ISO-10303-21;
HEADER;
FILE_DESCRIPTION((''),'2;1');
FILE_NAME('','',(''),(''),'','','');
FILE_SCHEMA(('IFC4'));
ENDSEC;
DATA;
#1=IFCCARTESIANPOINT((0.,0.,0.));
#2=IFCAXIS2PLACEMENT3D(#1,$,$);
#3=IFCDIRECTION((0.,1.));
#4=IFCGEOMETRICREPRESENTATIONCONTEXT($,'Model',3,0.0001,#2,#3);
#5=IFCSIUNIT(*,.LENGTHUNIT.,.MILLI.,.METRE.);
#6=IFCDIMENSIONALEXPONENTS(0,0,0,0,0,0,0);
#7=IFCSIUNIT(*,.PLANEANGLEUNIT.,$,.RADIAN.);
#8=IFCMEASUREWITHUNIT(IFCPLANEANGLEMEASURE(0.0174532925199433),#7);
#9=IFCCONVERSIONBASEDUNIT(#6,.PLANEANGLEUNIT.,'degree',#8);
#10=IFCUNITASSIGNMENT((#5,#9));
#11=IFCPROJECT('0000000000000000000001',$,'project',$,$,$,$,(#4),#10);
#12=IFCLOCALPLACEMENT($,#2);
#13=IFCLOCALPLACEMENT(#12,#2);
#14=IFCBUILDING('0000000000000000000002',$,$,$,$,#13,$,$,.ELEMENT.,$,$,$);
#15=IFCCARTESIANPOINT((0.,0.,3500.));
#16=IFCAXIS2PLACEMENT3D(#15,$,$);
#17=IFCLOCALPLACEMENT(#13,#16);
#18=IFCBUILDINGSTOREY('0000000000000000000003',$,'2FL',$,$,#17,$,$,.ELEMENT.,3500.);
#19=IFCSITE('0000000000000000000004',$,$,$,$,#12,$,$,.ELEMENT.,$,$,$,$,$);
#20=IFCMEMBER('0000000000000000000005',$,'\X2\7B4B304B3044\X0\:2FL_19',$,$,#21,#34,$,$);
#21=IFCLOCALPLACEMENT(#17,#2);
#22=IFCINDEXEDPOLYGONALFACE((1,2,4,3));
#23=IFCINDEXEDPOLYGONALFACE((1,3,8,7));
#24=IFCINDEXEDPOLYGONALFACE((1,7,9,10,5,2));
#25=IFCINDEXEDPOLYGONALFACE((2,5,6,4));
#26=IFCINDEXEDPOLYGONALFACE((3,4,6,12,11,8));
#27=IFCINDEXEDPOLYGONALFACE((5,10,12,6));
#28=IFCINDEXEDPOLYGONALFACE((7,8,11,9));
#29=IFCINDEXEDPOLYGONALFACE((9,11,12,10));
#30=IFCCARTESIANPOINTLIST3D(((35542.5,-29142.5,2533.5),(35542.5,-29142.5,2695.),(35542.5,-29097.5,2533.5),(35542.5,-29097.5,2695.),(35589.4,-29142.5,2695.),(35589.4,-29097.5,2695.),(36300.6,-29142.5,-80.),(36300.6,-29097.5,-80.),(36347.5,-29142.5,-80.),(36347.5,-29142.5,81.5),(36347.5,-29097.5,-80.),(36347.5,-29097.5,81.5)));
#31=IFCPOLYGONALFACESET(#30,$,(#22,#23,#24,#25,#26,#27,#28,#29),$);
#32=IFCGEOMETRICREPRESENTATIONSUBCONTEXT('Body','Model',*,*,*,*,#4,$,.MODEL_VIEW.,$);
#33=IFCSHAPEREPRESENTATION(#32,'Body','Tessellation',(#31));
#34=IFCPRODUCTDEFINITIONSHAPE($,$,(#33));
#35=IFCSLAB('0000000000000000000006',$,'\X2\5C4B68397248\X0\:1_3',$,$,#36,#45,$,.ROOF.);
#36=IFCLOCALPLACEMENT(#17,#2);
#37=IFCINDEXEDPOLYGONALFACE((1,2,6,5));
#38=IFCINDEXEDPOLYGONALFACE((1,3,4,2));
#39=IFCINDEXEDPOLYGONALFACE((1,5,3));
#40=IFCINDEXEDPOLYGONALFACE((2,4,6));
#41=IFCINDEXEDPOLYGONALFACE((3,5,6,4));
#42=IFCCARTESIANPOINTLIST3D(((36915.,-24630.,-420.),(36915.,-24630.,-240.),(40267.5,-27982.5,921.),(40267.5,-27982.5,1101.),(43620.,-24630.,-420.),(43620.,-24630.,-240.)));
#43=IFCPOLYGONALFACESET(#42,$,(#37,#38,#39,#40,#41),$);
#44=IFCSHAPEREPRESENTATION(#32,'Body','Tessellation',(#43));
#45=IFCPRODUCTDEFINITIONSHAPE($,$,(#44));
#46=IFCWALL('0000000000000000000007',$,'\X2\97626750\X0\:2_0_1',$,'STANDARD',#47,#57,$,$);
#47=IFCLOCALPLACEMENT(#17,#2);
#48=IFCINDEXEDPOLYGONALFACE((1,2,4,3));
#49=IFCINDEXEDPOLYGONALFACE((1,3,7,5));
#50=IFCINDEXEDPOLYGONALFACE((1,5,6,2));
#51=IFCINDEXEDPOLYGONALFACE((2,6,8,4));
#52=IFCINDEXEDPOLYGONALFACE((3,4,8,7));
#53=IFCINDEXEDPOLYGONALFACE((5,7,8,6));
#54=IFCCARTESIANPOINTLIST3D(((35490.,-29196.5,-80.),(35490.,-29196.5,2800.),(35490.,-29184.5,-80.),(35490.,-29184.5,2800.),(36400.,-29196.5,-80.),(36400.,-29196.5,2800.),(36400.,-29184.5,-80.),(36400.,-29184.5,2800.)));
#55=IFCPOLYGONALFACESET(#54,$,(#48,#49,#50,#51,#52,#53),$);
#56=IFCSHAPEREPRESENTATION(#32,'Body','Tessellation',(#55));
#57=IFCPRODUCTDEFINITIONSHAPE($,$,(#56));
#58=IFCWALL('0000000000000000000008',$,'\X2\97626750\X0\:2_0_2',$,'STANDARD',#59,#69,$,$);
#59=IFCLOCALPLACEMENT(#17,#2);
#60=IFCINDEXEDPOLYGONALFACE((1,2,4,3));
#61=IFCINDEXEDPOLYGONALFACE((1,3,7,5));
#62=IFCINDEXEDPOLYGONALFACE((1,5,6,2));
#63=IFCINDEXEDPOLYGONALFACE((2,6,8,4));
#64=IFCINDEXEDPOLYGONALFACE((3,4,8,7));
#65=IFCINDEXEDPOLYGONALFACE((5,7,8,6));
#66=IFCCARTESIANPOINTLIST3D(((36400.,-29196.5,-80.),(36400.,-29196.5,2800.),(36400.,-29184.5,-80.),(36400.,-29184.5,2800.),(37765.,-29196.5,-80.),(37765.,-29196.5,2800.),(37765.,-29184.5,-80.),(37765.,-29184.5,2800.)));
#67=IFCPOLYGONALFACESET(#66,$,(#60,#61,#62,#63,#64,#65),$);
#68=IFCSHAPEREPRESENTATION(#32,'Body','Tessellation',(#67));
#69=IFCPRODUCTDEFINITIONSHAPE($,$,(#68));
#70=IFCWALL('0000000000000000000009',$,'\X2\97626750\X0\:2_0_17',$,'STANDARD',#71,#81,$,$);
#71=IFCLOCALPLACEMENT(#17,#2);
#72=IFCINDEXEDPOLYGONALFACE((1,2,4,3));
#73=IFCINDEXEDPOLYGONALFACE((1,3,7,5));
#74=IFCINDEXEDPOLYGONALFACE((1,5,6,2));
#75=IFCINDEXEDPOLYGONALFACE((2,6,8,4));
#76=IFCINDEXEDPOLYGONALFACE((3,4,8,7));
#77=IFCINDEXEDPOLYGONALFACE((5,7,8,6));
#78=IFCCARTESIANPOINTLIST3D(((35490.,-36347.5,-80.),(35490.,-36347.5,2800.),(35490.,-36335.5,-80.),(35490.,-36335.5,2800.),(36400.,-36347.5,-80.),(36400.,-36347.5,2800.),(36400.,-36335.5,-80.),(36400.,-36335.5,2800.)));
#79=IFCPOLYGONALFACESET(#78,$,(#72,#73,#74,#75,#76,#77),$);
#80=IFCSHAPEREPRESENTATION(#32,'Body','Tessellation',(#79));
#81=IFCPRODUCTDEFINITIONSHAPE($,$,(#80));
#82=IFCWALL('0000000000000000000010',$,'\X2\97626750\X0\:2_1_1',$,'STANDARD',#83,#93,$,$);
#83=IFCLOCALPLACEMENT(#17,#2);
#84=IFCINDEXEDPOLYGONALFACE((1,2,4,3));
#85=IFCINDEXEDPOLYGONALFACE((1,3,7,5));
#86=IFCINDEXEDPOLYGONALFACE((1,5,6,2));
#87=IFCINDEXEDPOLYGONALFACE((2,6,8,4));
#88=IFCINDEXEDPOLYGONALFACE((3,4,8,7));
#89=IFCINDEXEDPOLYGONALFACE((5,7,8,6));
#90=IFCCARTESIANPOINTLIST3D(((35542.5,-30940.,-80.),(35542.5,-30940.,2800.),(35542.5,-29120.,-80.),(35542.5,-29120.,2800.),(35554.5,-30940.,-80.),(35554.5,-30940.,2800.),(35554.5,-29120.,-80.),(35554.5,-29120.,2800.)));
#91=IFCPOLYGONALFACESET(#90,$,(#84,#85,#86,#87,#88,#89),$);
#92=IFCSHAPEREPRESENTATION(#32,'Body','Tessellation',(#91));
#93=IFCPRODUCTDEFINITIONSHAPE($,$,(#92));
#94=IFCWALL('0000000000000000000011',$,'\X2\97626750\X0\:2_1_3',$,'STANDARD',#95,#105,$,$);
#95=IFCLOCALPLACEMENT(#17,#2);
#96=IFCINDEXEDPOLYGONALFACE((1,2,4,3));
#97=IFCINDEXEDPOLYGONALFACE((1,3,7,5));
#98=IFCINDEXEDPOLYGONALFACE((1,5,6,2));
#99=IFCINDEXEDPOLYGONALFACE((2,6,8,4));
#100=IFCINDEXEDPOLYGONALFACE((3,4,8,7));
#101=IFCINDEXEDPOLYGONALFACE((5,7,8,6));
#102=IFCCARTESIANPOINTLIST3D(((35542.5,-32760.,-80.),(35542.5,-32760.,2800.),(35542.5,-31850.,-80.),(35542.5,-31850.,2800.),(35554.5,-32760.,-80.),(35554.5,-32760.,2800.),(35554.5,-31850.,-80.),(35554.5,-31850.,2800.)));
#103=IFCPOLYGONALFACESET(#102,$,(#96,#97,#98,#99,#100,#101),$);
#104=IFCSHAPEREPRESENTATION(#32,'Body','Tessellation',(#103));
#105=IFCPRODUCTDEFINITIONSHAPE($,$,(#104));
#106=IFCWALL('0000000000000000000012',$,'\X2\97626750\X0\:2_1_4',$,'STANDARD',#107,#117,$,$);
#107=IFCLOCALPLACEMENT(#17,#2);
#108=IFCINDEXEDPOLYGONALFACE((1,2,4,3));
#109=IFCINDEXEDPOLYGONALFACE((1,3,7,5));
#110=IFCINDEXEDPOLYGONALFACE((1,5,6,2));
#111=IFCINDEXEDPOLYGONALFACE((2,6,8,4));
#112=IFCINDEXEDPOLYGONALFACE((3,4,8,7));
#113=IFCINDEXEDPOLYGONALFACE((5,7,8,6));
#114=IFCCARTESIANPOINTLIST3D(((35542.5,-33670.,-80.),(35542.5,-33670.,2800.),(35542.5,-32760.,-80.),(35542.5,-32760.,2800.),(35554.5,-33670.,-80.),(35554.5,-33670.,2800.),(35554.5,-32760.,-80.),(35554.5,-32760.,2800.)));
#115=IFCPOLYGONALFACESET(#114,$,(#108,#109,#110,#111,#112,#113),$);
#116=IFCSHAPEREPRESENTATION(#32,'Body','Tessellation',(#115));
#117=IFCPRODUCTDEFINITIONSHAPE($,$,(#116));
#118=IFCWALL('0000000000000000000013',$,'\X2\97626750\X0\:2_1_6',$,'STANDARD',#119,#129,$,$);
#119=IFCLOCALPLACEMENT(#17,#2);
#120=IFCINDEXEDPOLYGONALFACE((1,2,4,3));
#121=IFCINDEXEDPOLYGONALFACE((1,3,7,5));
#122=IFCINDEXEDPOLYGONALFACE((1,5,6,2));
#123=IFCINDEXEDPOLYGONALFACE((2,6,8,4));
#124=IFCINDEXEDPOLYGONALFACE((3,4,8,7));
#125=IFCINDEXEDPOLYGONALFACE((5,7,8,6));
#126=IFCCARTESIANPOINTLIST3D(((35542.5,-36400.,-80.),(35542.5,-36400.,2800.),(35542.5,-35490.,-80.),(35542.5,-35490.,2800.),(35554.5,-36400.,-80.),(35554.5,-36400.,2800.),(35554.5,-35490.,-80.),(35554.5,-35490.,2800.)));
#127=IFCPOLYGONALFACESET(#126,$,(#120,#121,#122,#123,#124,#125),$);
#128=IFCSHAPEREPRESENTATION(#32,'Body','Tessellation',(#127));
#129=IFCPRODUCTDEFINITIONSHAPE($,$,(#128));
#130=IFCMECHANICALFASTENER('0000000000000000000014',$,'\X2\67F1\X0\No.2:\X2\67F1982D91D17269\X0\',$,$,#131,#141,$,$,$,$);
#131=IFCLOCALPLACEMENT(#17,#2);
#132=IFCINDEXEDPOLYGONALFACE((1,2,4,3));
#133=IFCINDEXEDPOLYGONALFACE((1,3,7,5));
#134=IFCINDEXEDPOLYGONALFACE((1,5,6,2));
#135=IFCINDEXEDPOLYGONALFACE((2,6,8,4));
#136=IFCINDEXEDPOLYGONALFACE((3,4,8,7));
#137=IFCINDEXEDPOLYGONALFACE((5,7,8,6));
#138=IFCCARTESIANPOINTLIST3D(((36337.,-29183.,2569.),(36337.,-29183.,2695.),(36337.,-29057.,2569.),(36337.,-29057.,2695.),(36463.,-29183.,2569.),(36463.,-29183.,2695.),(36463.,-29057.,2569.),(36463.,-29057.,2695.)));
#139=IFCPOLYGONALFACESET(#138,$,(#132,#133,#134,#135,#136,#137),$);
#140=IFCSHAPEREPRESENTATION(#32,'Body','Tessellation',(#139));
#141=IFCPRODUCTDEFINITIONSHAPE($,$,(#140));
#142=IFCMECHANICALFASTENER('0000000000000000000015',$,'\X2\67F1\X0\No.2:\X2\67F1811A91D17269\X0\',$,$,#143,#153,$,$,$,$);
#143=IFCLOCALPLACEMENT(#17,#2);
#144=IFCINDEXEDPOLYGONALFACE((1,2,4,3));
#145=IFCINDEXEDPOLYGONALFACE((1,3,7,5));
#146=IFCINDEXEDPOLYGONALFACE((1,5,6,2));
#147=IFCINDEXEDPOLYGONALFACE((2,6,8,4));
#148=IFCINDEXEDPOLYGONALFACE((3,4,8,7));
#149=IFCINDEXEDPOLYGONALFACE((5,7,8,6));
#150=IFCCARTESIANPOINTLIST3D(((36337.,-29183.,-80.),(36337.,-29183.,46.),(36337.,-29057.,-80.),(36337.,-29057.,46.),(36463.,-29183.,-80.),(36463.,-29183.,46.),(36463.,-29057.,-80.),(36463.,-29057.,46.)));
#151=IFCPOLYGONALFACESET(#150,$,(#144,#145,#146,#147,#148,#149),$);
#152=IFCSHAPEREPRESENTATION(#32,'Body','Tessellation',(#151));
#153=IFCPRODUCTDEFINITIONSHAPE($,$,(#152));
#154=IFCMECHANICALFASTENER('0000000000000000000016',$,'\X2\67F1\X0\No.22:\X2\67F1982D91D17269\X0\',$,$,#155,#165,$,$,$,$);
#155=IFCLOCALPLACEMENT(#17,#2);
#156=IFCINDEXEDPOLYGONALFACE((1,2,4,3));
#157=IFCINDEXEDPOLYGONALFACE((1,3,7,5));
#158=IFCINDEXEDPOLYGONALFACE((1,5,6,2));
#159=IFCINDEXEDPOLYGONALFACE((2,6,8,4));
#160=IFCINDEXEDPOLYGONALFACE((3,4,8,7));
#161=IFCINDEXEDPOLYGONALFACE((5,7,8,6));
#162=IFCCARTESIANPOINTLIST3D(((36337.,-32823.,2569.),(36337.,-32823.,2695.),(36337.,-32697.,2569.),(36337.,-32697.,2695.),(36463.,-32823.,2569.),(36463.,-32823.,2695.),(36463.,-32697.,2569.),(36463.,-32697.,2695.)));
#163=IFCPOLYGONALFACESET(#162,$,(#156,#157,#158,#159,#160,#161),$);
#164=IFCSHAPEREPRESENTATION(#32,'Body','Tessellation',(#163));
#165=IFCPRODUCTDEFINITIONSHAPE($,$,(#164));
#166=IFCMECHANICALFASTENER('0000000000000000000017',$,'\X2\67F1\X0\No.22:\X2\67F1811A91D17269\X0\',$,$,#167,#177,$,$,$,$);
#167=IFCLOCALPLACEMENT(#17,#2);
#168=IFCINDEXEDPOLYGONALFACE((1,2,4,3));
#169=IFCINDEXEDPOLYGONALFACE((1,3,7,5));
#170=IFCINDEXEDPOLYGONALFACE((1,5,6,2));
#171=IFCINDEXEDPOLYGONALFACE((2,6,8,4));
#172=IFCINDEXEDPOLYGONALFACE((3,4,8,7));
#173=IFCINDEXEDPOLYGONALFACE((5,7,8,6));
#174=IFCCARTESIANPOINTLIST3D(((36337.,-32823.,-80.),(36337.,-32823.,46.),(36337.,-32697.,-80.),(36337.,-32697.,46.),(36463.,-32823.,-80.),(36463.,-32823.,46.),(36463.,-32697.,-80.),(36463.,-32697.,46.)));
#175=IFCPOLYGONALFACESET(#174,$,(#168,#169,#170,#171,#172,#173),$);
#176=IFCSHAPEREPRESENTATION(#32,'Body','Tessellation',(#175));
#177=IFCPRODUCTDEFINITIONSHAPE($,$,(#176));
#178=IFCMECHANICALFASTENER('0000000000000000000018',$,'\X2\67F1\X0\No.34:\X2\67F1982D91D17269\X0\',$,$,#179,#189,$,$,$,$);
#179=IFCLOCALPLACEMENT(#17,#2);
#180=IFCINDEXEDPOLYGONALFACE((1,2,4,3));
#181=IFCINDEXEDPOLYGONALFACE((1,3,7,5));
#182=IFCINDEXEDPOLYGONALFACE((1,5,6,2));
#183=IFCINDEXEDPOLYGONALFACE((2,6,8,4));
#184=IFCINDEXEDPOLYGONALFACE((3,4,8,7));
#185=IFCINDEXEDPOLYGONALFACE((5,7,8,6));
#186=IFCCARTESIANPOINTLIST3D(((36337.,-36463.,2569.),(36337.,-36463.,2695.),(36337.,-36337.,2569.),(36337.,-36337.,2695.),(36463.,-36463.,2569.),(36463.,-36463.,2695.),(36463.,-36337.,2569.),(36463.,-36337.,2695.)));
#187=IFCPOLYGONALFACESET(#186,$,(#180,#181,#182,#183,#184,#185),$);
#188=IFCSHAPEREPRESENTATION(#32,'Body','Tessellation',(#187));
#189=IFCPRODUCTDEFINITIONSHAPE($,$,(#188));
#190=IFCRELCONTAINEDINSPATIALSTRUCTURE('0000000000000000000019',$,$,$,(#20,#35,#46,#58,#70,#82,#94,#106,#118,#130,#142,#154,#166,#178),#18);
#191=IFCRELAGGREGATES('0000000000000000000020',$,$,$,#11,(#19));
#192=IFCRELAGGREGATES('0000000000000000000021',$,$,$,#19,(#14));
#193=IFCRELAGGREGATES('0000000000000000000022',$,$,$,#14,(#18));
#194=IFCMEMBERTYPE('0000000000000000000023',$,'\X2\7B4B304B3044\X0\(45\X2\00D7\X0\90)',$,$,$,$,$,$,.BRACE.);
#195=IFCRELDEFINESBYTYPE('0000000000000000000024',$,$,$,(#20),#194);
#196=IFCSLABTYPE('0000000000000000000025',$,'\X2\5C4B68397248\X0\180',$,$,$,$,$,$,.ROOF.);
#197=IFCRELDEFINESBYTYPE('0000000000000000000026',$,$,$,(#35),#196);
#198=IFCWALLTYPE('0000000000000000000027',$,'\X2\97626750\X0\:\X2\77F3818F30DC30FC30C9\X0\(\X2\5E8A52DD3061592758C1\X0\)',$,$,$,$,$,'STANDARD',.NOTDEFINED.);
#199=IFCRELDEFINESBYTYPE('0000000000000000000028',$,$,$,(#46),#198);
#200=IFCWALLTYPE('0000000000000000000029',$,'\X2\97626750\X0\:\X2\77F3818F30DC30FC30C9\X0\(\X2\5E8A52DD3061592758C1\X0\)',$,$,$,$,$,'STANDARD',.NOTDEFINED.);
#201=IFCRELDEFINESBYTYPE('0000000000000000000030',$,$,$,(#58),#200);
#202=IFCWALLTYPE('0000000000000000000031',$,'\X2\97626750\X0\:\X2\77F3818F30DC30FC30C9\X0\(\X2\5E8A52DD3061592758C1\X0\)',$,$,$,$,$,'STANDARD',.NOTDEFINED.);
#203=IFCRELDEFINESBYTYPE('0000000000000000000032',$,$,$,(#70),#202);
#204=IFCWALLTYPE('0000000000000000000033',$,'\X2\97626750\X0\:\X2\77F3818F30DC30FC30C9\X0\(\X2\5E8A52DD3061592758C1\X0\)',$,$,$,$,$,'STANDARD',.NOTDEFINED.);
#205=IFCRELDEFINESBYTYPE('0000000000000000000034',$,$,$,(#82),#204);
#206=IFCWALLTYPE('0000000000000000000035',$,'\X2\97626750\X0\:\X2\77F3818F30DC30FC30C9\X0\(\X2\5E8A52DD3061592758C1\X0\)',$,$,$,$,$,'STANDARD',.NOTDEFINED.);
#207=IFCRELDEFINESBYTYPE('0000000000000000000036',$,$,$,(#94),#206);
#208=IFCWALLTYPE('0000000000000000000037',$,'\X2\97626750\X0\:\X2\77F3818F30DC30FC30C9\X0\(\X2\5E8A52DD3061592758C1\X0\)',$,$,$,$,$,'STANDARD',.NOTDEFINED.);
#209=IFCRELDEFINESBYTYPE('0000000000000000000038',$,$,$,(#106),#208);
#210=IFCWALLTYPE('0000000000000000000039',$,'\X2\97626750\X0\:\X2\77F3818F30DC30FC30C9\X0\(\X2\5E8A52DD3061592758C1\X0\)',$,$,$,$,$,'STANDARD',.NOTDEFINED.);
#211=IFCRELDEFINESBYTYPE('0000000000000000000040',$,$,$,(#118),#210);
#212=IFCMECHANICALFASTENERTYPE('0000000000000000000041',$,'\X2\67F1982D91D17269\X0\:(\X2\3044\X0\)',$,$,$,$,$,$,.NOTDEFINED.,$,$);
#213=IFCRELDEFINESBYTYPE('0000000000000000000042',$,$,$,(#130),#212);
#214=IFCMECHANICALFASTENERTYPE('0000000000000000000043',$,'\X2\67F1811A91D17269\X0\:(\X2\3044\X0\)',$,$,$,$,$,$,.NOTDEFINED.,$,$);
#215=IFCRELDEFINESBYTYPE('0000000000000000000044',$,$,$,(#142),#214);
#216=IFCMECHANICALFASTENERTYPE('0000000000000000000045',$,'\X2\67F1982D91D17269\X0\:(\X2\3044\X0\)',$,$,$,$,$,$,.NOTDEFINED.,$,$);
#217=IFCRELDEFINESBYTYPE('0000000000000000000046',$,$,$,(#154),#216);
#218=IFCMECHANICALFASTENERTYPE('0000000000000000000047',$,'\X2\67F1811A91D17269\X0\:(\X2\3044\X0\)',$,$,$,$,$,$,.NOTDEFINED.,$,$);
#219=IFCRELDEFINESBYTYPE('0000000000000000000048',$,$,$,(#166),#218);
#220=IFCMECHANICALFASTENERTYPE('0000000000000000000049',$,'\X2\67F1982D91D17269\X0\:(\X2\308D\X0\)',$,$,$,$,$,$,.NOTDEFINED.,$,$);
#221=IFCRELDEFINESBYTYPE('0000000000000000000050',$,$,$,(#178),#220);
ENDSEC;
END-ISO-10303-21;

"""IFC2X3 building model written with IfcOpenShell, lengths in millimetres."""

from ifc_helpers import new_model, entity, si_unit, converted_unit, direction, frame, origin, origin_with_axes, origin_2d, place, context, subcontext, project, spatial, polyline, rectangle, outline, extrude, type_object, element, save


model = new_model("IFC2X3")

# Units and contexts
model_context = context("Model", 3, precision=0.0001, world=origin(), true_north=direction((0.0, 1.0)))
body_context = subcontext(model_context, "Body", "Model", "MODEL_VIEW")
ifc_project = project(units=[si_unit("LENGTHUNIT", "METRE", prefix="MILLI"), converted_unit("PLANEANGLEUNIT", "degree", entity("IfcPlaneAngleMeasure", 0.0174532925199433), si_unit("PLANEANGLEUNIT", "RADIAN"), dimensions=[0, 0, 0, 0, 0, 0, 0])], contexts=[model_context])

# Site, building, storey
site_placement = place(None, origin())
site = spatial("IfcSite", under=ifc_project, at=site_placement, CompositionType="ELEMENT")
building_placement = place(site_placement, origin())
building = spatial("IfcBuilding", under=site, at=building_placement, CompositionType="ELEMENT")
storey_placement = place(building_placement, frame((0.0, 0.0, 3500.0)))
storey = spatial("IfcBuildingStorey", under=building, at=storey_placement, Name="2FL", CompositionType="ELEMENT", Elevation=3500.0)

# Member
member_type_1 = type_object("IfcMemberType", Name="筋かい(45×90)", PredefinedType="BRACE")
member_1_placement = place(storey_placement, frame((36347.5, -29120.0, -80.0), z_axis=(-0.278604, 0.0, 0.960406), x_axis=(0.960406, 0.0, 0.278604)))
element("IfcMember", 1, at=member_1_placement, inside=storey, type_object=member_type_1, Name="筋かい:2FL_19", context=body_context, shape_type="SweptSolid", body=[
    extrude(outline(polyline([(0.0, 0.0), (13.1, -45.0), (2734.3, -45.0), (2889.4, 0.0), (2876.3, 45.0), (155.1, 45.0), (0.0, 0.0)])), frame((0.0, -22.5, 0.0), z_axis=(0.0, 1.0, 0.0), x_axis=(0.0, 0.0, 1.0)), (0.0, 0.0, 1.0), 45.0),
])

# Slab
slab_type = type_object("IfcSlabType", Name="屋根版180", PredefinedType="ROOF")
slab_placement = place(storey_placement, frame((36915.0, -24630.0, -420.0), z_axis=(0.0, -0.371391, -0.928477), x_axis=(1.0, 0.0, 0.0)))
element("IfcSlab", 2, at=slab_placement, inside=storey, type_object=slab_type, Name="屋根版:1_3", PredefinedType="ROOF", context=body_context, shape_type="SweptSolid", body=[
    extrude(outline(polyline([(0.0, 0.0, 0.0), (6705.0, 0.0, 0.0), (3352.5, 3610.8, 0.0), (0.0, 0.0, 0.0)])), origin_with_axes(), (0.0, 0.371391, -0.928477), 180.0),
])

# Walls
wall_type_1 = type_object("IfcWallType", Name="面材:石膏ボード(床勝ち大壁)", ElementType="STANDARD", PredefinedType="NOTDEFINED")
wall_1_placement = place(storey_placement, frame((35945.0, -29184.5, -80.0), z_axis=(0.0, -1.0, 0.0), x_axis=(1.0, 0.0, 0.0)))
element("IfcWall", 3, at=wall_1_placement, inside=storey, type_object=wall_type_1, Name="面材:2_0_1", ObjectType="STANDARD", context=body_context, shape_type="SweptSolid", body=[
    extrude(outline(polyline([(455.0, 0.0, 0.0), (-455.0, 0.0, 0.0), (-455.0, 2880.0, 0.0), (455.0, 2880.0, 0.0), (455.0, 0.0, 0.0)])), origin_with_axes(), (0.0, 0.0, 1.0), 12.0),
])
wall_type_2 = type_object("IfcWallType", Name="面材:石膏ボード(床勝ち大壁)", ElementType="STANDARD", PredefinedType="NOTDEFINED")
wall_2_placement = place(storey_placement, frame((37082.5, -29184.5, -80.0), z_axis=(0.0, -1.0, 0.0), x_axis=(1.0, 0.0, 0.0)))
element("IfcWall", 4, at=wall_2_placement, inside=storey, type_object=wall_type_2, Name="面材:2_0_2", ObjectType="STANDARD", context=body_context, shape_type="SweptSolid", body=[
    extrude(outline(polyline([(682.5, 0.0, 0.0), (-682.5, 0.0, 0.0), (-682.5, 2880.0, 0.0), (682.5, 2880.0, 0.0), (682.5, 0.0, 0.0)])), origin_with_axes(), (0.0, 0.0, 1.0), 12.0),
])
wall_type_3 = type_object("IfcWallType", Name="面材:石膏ボード(床勝ち大壁)", ElementType="STANDARD", PredefinedType="NOTDEFINED")
wall_3_placement = place(storey_placement, frame((35945.0, -36335.5, -80.0), z_axis=(0.0, -1.0, 0.0), x_axis=(1.0, 0.0, 0.0)))
element("IfcWall", 5, at=wall_3_placement, inside=storey, type_object=wall_type_3, Name="面材:2_0_17", ObjectType="STANDARD", context=body_context, shape_type="SweptSolid", body=[
    extrude(outline(polyline([(455.0, 0.0, 0.0), (-455.0, 0.0, 0.0), (-455.0, 2880.0, 0.0), (455.0, 2880.0, 0.0), (455.0, 0.0, 0.0)])), origin_with_axes(), (0.0, 0.0, 1.0), 12.0),
])
wall_type_4 = type_object("IfcWallType", Name="面材:石膏ボード(床勝ち大壁)", ElementType="STANDARD", PredefinedType="NOTDEFINED")
wall_4_placement = place(storey_placement, frame((35554.5, -30030.0, -80.0), z_axis=(-1.0, 0.0, 0.0), x_axis=(0.0, -1.0, 0.0)))
element("IfcWall", 6, at=wall_4_placement, inside=storey, type_object=wall_type_4, Name="面材:2_1_1", ObjectType="STANDARD", context=body_context, shape_type="SweptSolid", body=[
    extrude(outline(polyline([(910.0, 0.0, 0.0), (-910.0, 0.0, 0.0), (-910.0, 2880.0, 0.0), (910.0, 2880.0, 0.0), (910.0, 0.0, 0.0)])), origin_with_axes(), (0.0, 0.0, 1.0), 12.0),
])
wall_type_5 = type_object("IfcWallType", Name="面材:石膏ボード(床勝ち大壁)", ElementType="STANDARD", PredefinedType="NOTDEFINED")
wall_5_placement = place(storey_placement, frame((35554.5, -32305.0, -80.0), z_axis=(-1.0, 0.0, 0.0), x_axis=(0.0, -1.0, 0.0)))
element("IfcWall", 7, at=wall_5_placement, inside=storey, type_object=wall_type_5, Name="面材:2_1_3", ObjectType="STANDARD", context=body_context, shape_type="SweptSolid", body=[
    extrude(outline(polyline([(455.0, 0.0, 0.0), (-455.0, 0.0, 0.0), (-455.0, 2880.0, 0.0), (455.0, 2880.0, 0.0), (455.0, 0.0, 0.0)])), origin_with_axes(), (0.0, 0.0, 1.0), 12.0),
])
wall_type_6 = type_object("IfcWallType", Name="面材:石膏ボード(床勝ち大壁)", ElementType="STANDARD", PredefinedType="NOTDEFINED")
wall_6_placement = place(storey_placement, frame((35554.5, -33215.0, -80.0), z_axis=(-1.0, 0.0, 0.0), x_axis=(0.0, -1.0, 0.0)))
element("IfcWall", 8, at=wall_6_placement, inside=storey, type_object=wall_type_6, Name="面材:2_1_4", ObjectType="STANDARD", context=body_context, shape_type="SweptSolid", body=[
    extrude(outline(polyline([(455.0, 0.0, 0.0), (-455.0, 0.0, 0.0), (-455.0, 2880.0, 0.0), (455.0, 2880.0, 0.0), (455.0, 0.0, 0.0)])), origin_with_axes(), (0.0, 0.0, 1.0), 12.0),
])
wall_type_7 = type_object("IfcWallType", Name="面材:石膏ボード(床勝ち大壁)", ElementType="STANDARD", PredefinedType="NOTDEFINED")
wall_7_placement = place(storey_placement, frame((35554.5, -35945.0, -80.0), z_axis=(-1.0, 0.0, 0.0), x_axis=(0.0, -1.0, 0.0)))
element("IfcWall", 9, at=wall_7_placement, inside=storey, type_object=wall_type_7, Name="面材:2_1_6", ObjectType="STANDARD", context=body_context, shape_type="SweptSolid", body=[
    extrude(outline(polyline([(455.0, 0.0, 0.0), (-455.0, 0.0, 0.0), (-455.0, 2880.0, 0.0), (455.0, 2880.0, 0.0), (455.0, 0.0, 0.0)])), origin_with_axes(), (0.0, 0.0, 1.0), 12.0),
])

# Mechanical fasteners
mechanical_fastener_type_1 = type_object("IfcMechanicalFastenerType", Name="柱頭金物:(い)")
mechanical_fastener_1_placement = place(storey_placement, frame((36400.0, -29120.0, 2569.0)))
element("IfcMechanicalFastener", 10, at=mechanical_fastener_1_placement, inside=storey, type_object=mechanical_fastener_type_1, Name="柱No.2:柱頭金物", context=body_context, shape_type="SweptSolid", body=[
    extrude(rectangle(XDim=126.0, YDim=126.0, at=origin_2d()), origin_with_axes(), (0.0, 0.0, 1.0), 126.0),
])
mechanical_fastener_type_2 = type_object("IfcMechanicalFastenerType", Name="柱脚金物:(い)")
mechanical_fastener_2_placement = place(storey_placement, frame((36400.0, -29120.0, -80.0)))
element("IfcMechanicalFastener", 11, at=mechanical_fastener_2_placement, inside=storey, type_object=mechanical_fastener_type_2, Name="柱No.2:柱脚金物", context=body_context, shape_type="SweptSolid", body=[
    extrude(rectangle(XDim=126.0, YDim=126.0, at=origin_2d()), origin_with_axes(), (0.0, 0.0, 1.0), 126.0),
])
mechanical_fastener_type_3 = type_object("IfcMechanicalFastenerType", Name="柱頭金物:(い)")
mechanical_fastener_3_placement = place(storey_placement, frame((36400.0, -32760.0, 2569.0)))
element("IfcMechanicalFastener", 12, at=mechanical_fastener_3_placement, inside=storey, type_object=mechanical_fastener_type_3, Name="柱No.22:柱頭金物", context=body_context, shape_type="SweptSolid", body=[
    extrude(rectangle(XDim=126.0, YDim=126.0, at=origin_2d()), origin_with_axes(), (0.0, 0.0, 1.0), 126.0),
])
mechanical_fastener_type_4 = type_object("IfcMechanicalFastenerType", Name="柱脚金物:(い)")
mechanical_fastener_4_placement = place(storey_placement, frame((36400.0, -32760.0, -80.0)))
element("IfcMechanicalFastener", 13, at=mechanical_fastener_4_placement, inside=storey, type_object=mechanical_fastener_type_4, Name="柱No.22:柱脚金物", context=body_context, shape_type="SweptSolid", body=[
    extrude(rectangle(XDim=126.0, YDim=126.0, at=origin_2d()), origin_with_axes(), (0.0, 0.0, 1.0), 126.0),
])
mechanical_fastener_type_5 = type_object("IfcMechanicalFastenerType", Name="柱頭金物:(ろ)")
mechanical_fastener_5_placement = place(storey_placement, frame((36400.0, -36400.0, 2569.0)))
element("IfcMechanicalFastener", 14, at=mechanical_fastener_5_placement, inside=storey, type_object=mechanical_fastener_type_5, Name="柱No.34:柱頭金物", context=body_context, shape_type="SweptSolid", body=[
    extrude(rectangle(XDim=126.0, YDim=126.0, at=origin_2d()), origin_with_axes(), (0.0, 0.0, 1.0), 126.0),
])

save(model, "model.ifc")
